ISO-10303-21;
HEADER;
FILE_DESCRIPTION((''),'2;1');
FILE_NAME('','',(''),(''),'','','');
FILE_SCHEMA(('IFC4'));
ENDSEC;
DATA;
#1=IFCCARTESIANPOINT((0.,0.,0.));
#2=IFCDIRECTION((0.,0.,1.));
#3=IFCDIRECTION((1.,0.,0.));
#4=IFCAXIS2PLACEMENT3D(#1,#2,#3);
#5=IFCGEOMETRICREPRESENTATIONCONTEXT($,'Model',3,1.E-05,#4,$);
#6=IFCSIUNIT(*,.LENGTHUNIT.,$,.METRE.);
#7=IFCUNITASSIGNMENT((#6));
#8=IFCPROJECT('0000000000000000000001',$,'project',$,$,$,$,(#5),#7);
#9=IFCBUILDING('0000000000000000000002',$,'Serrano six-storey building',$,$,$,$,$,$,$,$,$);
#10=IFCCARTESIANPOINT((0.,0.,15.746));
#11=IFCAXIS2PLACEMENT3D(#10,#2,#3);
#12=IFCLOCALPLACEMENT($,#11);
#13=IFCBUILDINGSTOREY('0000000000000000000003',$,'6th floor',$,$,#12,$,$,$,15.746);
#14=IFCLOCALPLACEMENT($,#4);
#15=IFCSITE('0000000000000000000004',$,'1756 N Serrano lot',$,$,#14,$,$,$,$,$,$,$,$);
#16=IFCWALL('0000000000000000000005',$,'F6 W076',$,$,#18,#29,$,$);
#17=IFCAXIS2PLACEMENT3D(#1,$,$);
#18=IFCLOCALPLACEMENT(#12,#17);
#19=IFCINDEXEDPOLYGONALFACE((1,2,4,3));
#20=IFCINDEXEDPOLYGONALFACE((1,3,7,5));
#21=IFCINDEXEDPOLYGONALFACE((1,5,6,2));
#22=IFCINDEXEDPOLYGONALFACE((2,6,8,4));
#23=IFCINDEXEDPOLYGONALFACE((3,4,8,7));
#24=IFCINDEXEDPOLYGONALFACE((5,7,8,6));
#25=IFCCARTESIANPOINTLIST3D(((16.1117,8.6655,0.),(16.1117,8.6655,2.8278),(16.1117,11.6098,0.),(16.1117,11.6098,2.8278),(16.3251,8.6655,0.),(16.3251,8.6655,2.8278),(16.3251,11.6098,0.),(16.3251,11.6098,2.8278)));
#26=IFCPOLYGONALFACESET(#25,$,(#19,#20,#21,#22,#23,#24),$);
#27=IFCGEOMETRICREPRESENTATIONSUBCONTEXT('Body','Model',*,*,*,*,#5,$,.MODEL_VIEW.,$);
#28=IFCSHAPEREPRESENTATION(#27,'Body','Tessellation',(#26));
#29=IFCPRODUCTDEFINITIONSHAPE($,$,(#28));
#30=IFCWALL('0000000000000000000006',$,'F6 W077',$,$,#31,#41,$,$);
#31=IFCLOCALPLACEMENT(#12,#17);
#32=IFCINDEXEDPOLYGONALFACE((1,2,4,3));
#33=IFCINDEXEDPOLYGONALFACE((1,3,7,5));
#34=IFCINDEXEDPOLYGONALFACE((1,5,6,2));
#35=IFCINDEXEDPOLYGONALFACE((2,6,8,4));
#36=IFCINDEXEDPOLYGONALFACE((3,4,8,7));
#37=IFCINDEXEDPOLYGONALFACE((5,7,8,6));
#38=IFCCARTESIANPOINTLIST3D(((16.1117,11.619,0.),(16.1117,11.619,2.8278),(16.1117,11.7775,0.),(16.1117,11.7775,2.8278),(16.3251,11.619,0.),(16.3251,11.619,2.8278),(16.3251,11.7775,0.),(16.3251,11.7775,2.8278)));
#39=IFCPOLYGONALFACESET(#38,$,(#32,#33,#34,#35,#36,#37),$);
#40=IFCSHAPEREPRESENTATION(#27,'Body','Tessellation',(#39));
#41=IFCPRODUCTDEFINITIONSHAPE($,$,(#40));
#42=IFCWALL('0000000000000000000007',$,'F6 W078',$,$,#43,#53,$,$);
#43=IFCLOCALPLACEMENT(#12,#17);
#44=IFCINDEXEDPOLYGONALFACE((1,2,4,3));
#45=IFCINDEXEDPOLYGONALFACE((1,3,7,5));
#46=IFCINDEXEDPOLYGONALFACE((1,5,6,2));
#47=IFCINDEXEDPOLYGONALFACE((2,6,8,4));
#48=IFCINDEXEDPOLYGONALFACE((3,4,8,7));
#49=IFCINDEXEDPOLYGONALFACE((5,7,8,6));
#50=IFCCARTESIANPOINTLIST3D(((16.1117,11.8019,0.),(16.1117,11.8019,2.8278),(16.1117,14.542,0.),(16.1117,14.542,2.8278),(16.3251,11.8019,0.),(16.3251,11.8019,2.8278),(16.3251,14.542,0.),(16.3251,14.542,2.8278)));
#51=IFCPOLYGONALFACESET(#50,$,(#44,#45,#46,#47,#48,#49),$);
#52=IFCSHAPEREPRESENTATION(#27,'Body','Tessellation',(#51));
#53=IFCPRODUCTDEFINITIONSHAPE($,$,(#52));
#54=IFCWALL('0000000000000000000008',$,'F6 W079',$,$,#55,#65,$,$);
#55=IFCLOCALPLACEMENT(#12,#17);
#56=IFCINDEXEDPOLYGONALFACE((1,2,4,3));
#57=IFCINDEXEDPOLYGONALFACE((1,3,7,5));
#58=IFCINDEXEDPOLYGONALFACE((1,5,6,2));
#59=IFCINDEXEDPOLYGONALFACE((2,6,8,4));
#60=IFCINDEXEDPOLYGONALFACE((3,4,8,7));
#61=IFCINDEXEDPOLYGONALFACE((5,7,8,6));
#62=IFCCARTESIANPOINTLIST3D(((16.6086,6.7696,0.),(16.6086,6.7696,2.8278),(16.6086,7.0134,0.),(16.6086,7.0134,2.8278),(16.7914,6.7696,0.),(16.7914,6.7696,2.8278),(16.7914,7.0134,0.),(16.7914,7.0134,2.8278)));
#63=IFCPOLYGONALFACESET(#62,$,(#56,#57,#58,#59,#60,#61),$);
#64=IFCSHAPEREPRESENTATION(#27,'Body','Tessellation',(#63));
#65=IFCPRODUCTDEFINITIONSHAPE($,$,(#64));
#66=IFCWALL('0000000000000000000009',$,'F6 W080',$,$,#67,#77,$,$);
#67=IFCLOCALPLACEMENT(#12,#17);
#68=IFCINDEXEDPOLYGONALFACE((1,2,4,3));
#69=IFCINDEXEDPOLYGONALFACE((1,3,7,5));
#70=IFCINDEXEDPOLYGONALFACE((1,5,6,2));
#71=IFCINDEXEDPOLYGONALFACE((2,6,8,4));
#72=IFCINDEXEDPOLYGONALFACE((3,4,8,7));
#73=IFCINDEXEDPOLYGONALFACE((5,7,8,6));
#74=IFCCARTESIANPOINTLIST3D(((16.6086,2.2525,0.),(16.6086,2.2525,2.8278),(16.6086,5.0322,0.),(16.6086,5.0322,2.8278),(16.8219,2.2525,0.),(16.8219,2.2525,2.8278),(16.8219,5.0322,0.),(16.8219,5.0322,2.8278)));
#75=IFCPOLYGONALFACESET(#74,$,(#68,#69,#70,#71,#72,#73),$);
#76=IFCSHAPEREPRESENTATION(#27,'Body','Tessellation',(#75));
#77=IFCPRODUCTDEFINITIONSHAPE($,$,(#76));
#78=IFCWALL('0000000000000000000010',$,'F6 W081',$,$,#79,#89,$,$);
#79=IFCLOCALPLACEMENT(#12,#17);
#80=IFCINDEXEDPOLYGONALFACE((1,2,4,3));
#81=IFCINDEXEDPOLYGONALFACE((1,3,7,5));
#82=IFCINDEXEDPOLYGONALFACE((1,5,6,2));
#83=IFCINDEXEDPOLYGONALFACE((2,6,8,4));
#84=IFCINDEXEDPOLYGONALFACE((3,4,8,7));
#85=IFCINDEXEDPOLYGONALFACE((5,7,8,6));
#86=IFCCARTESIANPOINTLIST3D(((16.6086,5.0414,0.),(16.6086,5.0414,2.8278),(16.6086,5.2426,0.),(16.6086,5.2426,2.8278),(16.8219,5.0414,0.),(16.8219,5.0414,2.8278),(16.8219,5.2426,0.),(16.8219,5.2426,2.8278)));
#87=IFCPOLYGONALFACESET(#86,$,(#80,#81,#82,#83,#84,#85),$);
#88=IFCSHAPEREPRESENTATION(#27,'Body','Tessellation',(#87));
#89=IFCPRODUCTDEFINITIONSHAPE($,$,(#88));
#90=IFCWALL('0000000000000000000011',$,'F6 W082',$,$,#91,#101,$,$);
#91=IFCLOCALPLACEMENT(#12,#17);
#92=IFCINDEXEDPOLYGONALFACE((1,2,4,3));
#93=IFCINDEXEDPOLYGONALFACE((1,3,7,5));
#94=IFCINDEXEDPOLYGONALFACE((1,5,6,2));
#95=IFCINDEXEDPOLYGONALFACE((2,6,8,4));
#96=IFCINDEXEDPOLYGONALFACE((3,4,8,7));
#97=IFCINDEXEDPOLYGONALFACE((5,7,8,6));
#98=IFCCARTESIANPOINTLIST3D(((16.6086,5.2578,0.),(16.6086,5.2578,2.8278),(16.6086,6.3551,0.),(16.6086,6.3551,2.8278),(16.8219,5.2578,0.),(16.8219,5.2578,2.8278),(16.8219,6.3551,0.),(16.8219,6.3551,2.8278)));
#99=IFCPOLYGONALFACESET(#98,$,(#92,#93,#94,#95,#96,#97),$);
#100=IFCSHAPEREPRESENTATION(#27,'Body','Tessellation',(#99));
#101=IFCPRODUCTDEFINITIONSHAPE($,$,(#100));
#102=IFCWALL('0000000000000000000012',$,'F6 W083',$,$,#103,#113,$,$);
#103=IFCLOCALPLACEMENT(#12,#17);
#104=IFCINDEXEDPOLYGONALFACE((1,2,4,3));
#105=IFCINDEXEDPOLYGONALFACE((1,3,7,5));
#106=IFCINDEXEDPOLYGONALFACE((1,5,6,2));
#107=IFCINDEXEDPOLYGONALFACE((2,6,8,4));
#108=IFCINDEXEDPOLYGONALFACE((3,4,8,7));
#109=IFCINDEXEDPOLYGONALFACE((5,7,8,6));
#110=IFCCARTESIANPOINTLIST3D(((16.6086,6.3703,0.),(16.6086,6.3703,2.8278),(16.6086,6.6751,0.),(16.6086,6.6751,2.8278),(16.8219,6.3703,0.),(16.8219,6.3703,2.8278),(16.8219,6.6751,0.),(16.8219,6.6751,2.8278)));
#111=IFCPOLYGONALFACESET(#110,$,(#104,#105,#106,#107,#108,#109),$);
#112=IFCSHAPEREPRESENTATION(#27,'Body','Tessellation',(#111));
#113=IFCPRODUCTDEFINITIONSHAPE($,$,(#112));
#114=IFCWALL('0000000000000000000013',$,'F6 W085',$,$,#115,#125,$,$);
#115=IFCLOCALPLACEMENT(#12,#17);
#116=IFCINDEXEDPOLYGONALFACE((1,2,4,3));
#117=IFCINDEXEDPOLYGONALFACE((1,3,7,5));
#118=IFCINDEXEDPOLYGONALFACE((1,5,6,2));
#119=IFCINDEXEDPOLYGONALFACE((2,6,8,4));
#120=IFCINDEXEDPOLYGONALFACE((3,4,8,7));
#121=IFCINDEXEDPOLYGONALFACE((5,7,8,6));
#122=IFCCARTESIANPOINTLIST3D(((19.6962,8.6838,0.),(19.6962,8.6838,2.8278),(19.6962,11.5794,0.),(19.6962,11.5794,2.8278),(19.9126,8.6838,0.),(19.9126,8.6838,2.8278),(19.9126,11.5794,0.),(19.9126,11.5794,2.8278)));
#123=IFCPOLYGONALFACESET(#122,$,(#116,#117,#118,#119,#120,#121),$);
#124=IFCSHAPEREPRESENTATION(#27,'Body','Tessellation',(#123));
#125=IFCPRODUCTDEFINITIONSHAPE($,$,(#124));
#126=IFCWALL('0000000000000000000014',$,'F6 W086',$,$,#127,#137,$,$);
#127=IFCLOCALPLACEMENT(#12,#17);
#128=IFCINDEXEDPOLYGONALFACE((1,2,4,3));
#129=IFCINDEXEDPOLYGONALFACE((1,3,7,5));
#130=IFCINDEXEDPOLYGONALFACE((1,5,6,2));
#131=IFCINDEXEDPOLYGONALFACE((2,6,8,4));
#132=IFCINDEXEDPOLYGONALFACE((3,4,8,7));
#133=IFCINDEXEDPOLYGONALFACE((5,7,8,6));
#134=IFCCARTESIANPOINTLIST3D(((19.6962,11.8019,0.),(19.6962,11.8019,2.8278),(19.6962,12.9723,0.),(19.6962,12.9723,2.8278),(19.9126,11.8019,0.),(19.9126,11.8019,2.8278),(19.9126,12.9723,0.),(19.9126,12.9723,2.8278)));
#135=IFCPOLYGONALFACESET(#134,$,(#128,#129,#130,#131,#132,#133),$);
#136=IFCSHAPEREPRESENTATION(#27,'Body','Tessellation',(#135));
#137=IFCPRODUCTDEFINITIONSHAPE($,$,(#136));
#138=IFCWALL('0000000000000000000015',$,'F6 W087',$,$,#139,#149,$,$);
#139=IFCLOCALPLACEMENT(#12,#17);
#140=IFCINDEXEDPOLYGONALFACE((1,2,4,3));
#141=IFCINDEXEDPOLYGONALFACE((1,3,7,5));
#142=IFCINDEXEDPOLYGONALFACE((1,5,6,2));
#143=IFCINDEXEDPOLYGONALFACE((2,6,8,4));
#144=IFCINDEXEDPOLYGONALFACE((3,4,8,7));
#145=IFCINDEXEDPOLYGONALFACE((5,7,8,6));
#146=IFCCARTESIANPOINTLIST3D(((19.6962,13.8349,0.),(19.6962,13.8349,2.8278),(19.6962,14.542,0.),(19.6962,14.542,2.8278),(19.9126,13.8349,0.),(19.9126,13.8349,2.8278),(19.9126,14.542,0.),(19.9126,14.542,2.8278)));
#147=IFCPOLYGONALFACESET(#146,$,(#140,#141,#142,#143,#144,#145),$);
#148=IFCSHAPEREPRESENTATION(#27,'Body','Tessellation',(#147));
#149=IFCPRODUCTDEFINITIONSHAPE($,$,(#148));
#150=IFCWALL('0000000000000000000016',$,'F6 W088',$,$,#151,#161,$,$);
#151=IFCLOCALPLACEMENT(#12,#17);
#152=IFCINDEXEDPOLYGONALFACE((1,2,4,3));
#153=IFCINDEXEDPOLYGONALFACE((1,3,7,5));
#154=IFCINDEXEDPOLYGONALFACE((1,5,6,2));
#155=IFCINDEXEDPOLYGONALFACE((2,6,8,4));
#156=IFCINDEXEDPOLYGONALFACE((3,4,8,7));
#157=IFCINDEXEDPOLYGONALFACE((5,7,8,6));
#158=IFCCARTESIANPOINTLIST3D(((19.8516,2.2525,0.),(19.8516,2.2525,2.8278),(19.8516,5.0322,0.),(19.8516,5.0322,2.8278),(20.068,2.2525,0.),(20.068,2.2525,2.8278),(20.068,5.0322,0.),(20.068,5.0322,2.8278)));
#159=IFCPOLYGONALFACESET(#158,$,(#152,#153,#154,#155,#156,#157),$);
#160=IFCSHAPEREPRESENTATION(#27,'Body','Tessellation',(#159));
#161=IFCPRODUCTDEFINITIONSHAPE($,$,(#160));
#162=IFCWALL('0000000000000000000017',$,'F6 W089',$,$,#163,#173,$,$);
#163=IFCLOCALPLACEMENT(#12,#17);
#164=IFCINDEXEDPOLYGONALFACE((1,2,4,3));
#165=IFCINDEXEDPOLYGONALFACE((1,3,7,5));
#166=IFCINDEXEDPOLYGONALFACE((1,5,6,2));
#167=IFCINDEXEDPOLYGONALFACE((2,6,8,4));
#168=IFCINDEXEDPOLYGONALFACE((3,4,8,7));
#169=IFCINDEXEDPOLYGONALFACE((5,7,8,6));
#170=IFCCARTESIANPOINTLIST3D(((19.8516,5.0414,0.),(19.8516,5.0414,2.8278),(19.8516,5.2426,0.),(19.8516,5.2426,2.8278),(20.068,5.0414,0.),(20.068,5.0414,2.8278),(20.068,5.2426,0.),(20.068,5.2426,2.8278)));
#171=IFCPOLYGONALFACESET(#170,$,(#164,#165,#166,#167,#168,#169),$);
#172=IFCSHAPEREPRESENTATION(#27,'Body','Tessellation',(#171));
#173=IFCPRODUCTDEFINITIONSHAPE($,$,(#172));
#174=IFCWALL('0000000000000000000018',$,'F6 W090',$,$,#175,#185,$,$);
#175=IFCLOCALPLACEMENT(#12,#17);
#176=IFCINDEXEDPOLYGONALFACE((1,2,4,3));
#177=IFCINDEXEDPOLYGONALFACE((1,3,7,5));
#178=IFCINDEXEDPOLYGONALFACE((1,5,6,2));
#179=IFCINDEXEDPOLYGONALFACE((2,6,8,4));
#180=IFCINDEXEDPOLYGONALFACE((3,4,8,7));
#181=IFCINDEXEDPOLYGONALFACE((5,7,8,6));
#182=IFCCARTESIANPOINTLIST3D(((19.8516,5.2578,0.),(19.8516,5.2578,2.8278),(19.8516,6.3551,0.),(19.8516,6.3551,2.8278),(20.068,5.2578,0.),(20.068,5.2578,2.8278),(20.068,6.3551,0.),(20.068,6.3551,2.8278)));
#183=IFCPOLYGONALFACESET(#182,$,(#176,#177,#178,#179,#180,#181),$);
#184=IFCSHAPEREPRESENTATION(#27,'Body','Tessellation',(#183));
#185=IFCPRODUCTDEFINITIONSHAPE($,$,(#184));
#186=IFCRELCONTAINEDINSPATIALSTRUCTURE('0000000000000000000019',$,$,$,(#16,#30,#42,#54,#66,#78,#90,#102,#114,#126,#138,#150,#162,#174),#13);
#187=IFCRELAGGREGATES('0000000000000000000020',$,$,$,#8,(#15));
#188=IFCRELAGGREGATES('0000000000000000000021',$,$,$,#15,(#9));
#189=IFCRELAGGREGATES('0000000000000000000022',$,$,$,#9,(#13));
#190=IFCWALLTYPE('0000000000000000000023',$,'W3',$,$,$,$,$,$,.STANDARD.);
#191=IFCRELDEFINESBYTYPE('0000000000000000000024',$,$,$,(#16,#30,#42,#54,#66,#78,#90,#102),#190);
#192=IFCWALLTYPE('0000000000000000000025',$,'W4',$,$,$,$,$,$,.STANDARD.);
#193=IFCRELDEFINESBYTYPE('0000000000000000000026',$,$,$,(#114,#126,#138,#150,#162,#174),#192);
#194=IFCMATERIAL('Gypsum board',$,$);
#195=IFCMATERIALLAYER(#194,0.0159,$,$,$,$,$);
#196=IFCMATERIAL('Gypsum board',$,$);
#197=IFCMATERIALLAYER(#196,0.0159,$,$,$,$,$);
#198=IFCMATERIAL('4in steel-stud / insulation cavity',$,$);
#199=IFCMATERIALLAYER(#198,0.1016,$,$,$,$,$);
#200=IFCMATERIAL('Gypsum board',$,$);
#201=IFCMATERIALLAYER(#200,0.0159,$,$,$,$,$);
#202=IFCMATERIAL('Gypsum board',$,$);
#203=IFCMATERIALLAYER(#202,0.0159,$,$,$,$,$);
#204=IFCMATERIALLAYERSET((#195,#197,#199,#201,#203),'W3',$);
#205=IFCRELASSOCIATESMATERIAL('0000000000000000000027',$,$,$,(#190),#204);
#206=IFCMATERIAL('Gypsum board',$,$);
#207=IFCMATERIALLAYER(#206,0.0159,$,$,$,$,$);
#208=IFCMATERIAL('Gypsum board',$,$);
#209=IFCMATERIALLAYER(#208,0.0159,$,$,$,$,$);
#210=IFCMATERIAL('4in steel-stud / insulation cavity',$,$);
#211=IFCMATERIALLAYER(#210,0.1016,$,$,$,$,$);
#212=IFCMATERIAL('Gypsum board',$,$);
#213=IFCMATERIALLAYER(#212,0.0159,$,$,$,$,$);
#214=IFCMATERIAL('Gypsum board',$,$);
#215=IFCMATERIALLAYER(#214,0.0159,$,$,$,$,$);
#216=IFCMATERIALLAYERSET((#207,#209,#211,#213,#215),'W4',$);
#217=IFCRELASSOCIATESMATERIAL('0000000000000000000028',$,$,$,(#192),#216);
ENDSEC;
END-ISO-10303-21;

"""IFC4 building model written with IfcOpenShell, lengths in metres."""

from ifc_helpers import new_model, si_unit, frame, origin_with_axes, place, context, subcontext, project, spatial, polyline, outline, extrude, material, layer, layer_set, type_object, element, save


model = new_model("IFC4")

# Units and contexts
model_context = context("Model", 3, precision=1e-05, world=origin_with_axes())
body_context = subcontext(model_context, "Body", "Model", "MODEL_VIEW")
ifc_project = project(units=[si_unit("LENGTHUNIT", "METRE")], contexts=[model_context])

# Site, building, storey
site_placement = place(None, origin_with_axes())
site = spatial("IfcSite", under=ifc_project, at=site_placement, Name="1756 N Serrano lot")
building = spatial("IfcBuilding", under=site, Name="Serrano six-storey building")
storey_placement = place(None, frame((0.0, 0.0, 15.746), z_axis=(0.0, 0.0, 1.0), x_axis=(1.0, 0.0, 0.0)))
storey = spatial("IfcBuildingStorey", under=building, at=storey_placement, Name="6th floor", Elevation=15.746)

# Walls
ifc_material_1 = material(Name="Gypsum board")
ifc_layer_1 = layer(ifc_material_1, 0.0159)
ifc_material_2 = material(Name="Gypsum board")
ifc_layer_2 = layer(ifc_material_2, 0.0159)
ifc_material_3 = material(Name="4in steel-stud / insulation cavity")
ifc_layer_3 = layer(ifc_material_3, 0.1016)
ifc_material_4 = material(Name="Gypsum board")
ifc_layer_4 = layer(ifc_material_4, 0.0159)
ifc_material_5 = material(Name="Gypsum board")
ifc_layer_5 = layer(ifc_material_5, 0.0159)
ifc_layer_set_1 = layer_set([ifc_layer_1, ifc_layer_2, ifc_layer_3, ifc_layer_4, ifc_layer_5], Name="W3")
wall_type_1 = type_object("IfcWallType", Name="W3", PredefinedType="STANDARD", material=ifc_layer_set_1)
wall_1_placement = place(storey_placement, frame((0.0, 0.0, -15.746), z_axis=(0.0, 0.0, 1.0), x_axis=(1.0, 0.0, 0.0)))
element("IfcWall", 1, at=wall_1_placement, inside=storey, type_object=wall_type_1, Name="F6 W076", context=body_context, shape_type="SweptSolid", body=[
    extrude(outline(polyline([(16.1117, 11.6098), (16.3251, 11.6098), (16.3251, 8.6655), (16.1117, 8.6655), (16.1117, 11.6098)])), frame((0.0, 0.0, 15.746)), (0.0, 0.0, 1.0), 2.8278),
])
wall_2_placement = place(storey_placement, frame((0.0, 0.0, -15.746), z_axis=(0.0, 0.0, 1.0), x_axis=(1.0, 0.0, 0.0)))
element("IfcWall", 2, at=wall_2_placement, inside=storey, type_object=wall_type_1, Name="F6 W077", context=body_context, shape_type="SweptSolid", body=[
    extrude(outline(polyline([(16.1117, 11.7775), (16.3251, 11.7775), (16.3251, 11.619), (16.1117, 11.619), (16.1117, 11.7775)])), frame((0.0, 0.0, 15.746)), (0.0, 0.0, 1.0), 2.8278),
])
wall_3_placement = place(storey_placement, frame((0.0, 0.0, -15.746), z_axis=(0.0, 0.0, 1.0), x_axis=(1.0, 0.0, 0.0)))
element("IfcWall", 3, at=wall_3_placement, inside=storey, type_object=wall_type_1, Name="F6 W078", context=body_context, shape_type="SweptSolid", body=[
    extrude(outline(polyline([(16.1117, 14.542), (16.3251, 14.542), (16.3251, 11.8019), (16.1117, 11.8019), (16.1117, 14.542)])), frame((0.0, 0.0, 15.746)), (0.0, 0.0, 1.0), 2.8278),
])
wall_4_placement = place(storey_placement, frame((0.0, 0.0, -15.746), z_axis=(0.0, 0.0, 1.0), x_axis=(1.0, 0.0, 0.0)))
element("IfcWall", 4, at=wall_4_placement, inside=storey, type_object=wall_type_1, Name="F6 W079", context=body_context, shape_type="SweptSolid", body=[
    extrude(outline(polyline([(16.6086, 7.0134), (16.7914, 7.0134), (16.7914, 6.7696), (16.6086, 6.7696), (16.6086, 7.0134)])), frame((0.0, 0.0, 15.746)), (0.0, 0.0, 1.0), 2.8278),
])
wall_5_placement = place(storey_placement, frame((0.0, 0.0, -15.746), z_axis=(0.0, 0.0, 1.0), x_axis=(1.0, 0.0, 0.0)))
element("IfcWall", 5, at=wall_5_placement, inside=storey, type_object=wall_type_1, Name="F6 W080", context=body_context, shape_type="SweptSolid", body=[
    extrude(outline(polyline([(16.6086, 5.0322), (16.8219, 5.0322), (16.8219, 2.2525), (16.6086, 2.2525), (16.6086, 5.0322)])), frame((0.0, 0.0, 15.746)), (0.0, 0.0, 1.0), 2.8278),
])
wall_6_placement = place(storey_placement, frame((0.0, 0.0, -15.746), z_axis=(0.0, 0.0, 1.0), x_axis=(1.0, 0.0, 0.0)))
element("IfcWall", 6, at=wall_6_placement, inside=storey, type_object=wall_type_1, Name="F6 W081", context=body_context, shape_type="SweptSolid", body=[
    extrude(outline(polyline([(16.6086, 5.2426), (16.8219, 5.2426), (16.8219, 5.0414), (16.6086, 5.0414), (16.6086, 5.2426)])), frame((0.0, 0.0, 15.746)), (0.0, 0.0, 1.0), 2.8278),
])
wall_7_placement = place(storey_placement, frame((0.0, 0.0, -15.746), z_axis=(0.0, 0.0, 1.0), x_axis=(1.0, 0.0, 0.0)))
element("IfcWall", 7, at=wall_7_placement, inside=storey, type_object=wall_type_1, Name="F6 W082", context=body_context, shape_type="SweptSolid", body=[
    extrude(outline(polyline([(16.6086, 6.3551), (16.8219, 6.3551), (16.8219, 5.2578), (16.6086, 5.2578), (16.6086, 6.3551)])), frame((0.0, 0.0, 15.746)), (0.0, 0.0, 1.0), 2.8278),
])
wall_8_placement = place(storey_placement, frame((0.0, 0.0, -15.746), z_axis=(0.0, 0.0, 1.0), x_axis=(1.0, 0.0, 0.0)))
element("IfcWall", 8, at=wall_8_placement, inside=storey, type_object=wall_type_1, Name="F6 W083", context=body_context, shape_type="SweptSolid", body=[
    extrude(outline(polyline([(16.6086, 6.6751), (16.8219, 6.6751), (16.8219, 6.3703), (16.6086, 6.3703), (16.6086, 6.6751)])), frame((0.0, 0.0, 15.746)), (0.0, 0.0, 1.0), 2.8278),
])
ifc_material_6 = material(Name="Gypsum board")
ifc_layer_6 = layer(ifc_material_6, 0.0159)
ifc_material_7 = material(Name="Gypsum board")
ifc_layer_7 = layer(ifc_material_7, 0.0159)
ifc_material_8 = material(Name="4in steel-stud / insulation cavity")
ifc_layer_8 = layer(ifc_material_8, 0.1016)
ifc_material_9 = material(Name="Gypsum board")
ifc_layer_9 = layer(ifc_material_9, 0.0159)
ifc_material_10 = material(Name="Gypsum board")
ifc_layer_10 = layer(ifc_material_10, 0.0159)
ifc_layer_set_2 = layer_set([ifc_layer_6, ifc_layer_7, ifc_layer_8, ifc_layer_9, ifc_layer_10], Name="W4")
wall_type_2 = type_object("IfcWallType", Name="W4", PredefinedType="STANDARD", material=ifc_layer_set_2)
wall_9_placement = place(storey_placement, frame((0.0, 0.0, -15.746), z_axis=(0.0, 0.0, 1.0), x_axis=(1.0, 0.0, 0.0)))
element("IfcWall", 9, at=wall_9_placement, inside=storey, type_object=wall_type_2, Name="F6 W085", context=body_context, shape_type="SweptSolid", body=[
    extrude(outline(polyline([(19.6962, 11.5794), (19.9126, 11.5794), (19.9126, 8.6838), (19.6962, 8.6838), (19.6962, 11.5794)])), frame((0.0, 0.0, 15.746)), (0.0, 0.0, 1.0), 2.8278),
])
wall_10_placement = place(storey_placement, frame((0.0, 0.0, -15.746), z_axis=(0.0, 0.0, 1.0), x_axis=(1.0, 0.0, 0.0)))
element("IfcWall", 10, at=wall_10_placement, inside=storey, type_object=wall_type_2, Name="F6 W086", context=body_context, shape_type="SweptSolid", body=[
    extrude(outline(polyline([(19.6962, 12.9723), (19.9126, 12.9723), (19.9126, 11.8019), (19.6962, 11.8019), (19.6962, 12.9723)])), frame((0.0, 0.0, 15.746)), (0.0, 0.0, 1.0), 2.8278),
])
wall_11_placement = place(storey_placement, frame((0.0, 0.0, -15.746), z_axis=(0.0, 0.0, 1.0), x_axis=(1.0, 0.0, 0.0)))
element("IfcWall", 11, at=wall_11_placement, inside=storey, type_object=wall_type_2, Name="F6 W087", context=body_context, shape_type="SweptSolid", body=[
    extrude(outline(polyline([(19.6962, 14.542), (19.9126, 14.542), (19.9126, 13.8349), (19.6962, 13.8349), (19.6962, 14.542)])), frame((0.0, 0.0, 15.746)), (0.0, 0.0, 1.0), 2.8278),
])
wall_12_placement = place(storey_placement, frame((0.0, 0.0, -15.746), z_axis=(0.0, 0.0, 1.0), x_axis=(1.0, 0.0, 0.0)))
element("IfcWall", 12, at=wall_12_placement, inside=storey, type_object=wall_type_2, Name="F6 W088", context=body_context, shape_type="SweptSolid", body=[
    extrude(outline(polyline([(19.8516, 5.0322), (20.068, 5.0322), (20.068, 2.2525), (19.8516, 2.2525), (19.8516, 5.0322)])), frame((0.0, 0.0, 15.746)), (0.0, 0.0, 1.0), 2.8278),
])
wall_13_placement = place(storey_placement, frame((0.0, 0.0, -15.746), z_axis=(0.0, 0.0, 1.0), x_axis=(1.0, 0.0, 0.0)))
element("IfcWall", 13, at=wall_13_placement, inside=storey, type_object=wall_type_2, Name="F6 W089", context=body_context, shape_type="SweptSolid", body=[
    extrude(outline(polyline([(19.8516, 5.2426), (20.068, 5.2426), (20.068, 5.0414), (19.8516, 5.0414), (19.8516, 5.2426)])), frame((0.0, 0.0, 15.746)), (0.0, 0.0, 1.0), 2.8278),
])
wall_14_placement = place(storey_placement, frame((0.0, 0.0, -15.746), z_axis=(0.0, 0.0, 1.0), x_axis=(1.0, 0.0, 0.0)))
element("IfcWall", 14, at=wall_14_placement, inside=storey, type_object=wall_type_2, Name="F6 W090", context=body_context, shape_type="SweptSolid", body=[
    extrude(outline(polyline([(19.8516, 6.3551), (20.068, 6.3551), (20.068, 5.2578), (19.8516, 5.2578), (19.8516, 6.3551)])), frame((0.0, 0.0, 15.746)), (0.0, 0.0, 1.0), 2.8278),
])

save(model, "model.ifc")
